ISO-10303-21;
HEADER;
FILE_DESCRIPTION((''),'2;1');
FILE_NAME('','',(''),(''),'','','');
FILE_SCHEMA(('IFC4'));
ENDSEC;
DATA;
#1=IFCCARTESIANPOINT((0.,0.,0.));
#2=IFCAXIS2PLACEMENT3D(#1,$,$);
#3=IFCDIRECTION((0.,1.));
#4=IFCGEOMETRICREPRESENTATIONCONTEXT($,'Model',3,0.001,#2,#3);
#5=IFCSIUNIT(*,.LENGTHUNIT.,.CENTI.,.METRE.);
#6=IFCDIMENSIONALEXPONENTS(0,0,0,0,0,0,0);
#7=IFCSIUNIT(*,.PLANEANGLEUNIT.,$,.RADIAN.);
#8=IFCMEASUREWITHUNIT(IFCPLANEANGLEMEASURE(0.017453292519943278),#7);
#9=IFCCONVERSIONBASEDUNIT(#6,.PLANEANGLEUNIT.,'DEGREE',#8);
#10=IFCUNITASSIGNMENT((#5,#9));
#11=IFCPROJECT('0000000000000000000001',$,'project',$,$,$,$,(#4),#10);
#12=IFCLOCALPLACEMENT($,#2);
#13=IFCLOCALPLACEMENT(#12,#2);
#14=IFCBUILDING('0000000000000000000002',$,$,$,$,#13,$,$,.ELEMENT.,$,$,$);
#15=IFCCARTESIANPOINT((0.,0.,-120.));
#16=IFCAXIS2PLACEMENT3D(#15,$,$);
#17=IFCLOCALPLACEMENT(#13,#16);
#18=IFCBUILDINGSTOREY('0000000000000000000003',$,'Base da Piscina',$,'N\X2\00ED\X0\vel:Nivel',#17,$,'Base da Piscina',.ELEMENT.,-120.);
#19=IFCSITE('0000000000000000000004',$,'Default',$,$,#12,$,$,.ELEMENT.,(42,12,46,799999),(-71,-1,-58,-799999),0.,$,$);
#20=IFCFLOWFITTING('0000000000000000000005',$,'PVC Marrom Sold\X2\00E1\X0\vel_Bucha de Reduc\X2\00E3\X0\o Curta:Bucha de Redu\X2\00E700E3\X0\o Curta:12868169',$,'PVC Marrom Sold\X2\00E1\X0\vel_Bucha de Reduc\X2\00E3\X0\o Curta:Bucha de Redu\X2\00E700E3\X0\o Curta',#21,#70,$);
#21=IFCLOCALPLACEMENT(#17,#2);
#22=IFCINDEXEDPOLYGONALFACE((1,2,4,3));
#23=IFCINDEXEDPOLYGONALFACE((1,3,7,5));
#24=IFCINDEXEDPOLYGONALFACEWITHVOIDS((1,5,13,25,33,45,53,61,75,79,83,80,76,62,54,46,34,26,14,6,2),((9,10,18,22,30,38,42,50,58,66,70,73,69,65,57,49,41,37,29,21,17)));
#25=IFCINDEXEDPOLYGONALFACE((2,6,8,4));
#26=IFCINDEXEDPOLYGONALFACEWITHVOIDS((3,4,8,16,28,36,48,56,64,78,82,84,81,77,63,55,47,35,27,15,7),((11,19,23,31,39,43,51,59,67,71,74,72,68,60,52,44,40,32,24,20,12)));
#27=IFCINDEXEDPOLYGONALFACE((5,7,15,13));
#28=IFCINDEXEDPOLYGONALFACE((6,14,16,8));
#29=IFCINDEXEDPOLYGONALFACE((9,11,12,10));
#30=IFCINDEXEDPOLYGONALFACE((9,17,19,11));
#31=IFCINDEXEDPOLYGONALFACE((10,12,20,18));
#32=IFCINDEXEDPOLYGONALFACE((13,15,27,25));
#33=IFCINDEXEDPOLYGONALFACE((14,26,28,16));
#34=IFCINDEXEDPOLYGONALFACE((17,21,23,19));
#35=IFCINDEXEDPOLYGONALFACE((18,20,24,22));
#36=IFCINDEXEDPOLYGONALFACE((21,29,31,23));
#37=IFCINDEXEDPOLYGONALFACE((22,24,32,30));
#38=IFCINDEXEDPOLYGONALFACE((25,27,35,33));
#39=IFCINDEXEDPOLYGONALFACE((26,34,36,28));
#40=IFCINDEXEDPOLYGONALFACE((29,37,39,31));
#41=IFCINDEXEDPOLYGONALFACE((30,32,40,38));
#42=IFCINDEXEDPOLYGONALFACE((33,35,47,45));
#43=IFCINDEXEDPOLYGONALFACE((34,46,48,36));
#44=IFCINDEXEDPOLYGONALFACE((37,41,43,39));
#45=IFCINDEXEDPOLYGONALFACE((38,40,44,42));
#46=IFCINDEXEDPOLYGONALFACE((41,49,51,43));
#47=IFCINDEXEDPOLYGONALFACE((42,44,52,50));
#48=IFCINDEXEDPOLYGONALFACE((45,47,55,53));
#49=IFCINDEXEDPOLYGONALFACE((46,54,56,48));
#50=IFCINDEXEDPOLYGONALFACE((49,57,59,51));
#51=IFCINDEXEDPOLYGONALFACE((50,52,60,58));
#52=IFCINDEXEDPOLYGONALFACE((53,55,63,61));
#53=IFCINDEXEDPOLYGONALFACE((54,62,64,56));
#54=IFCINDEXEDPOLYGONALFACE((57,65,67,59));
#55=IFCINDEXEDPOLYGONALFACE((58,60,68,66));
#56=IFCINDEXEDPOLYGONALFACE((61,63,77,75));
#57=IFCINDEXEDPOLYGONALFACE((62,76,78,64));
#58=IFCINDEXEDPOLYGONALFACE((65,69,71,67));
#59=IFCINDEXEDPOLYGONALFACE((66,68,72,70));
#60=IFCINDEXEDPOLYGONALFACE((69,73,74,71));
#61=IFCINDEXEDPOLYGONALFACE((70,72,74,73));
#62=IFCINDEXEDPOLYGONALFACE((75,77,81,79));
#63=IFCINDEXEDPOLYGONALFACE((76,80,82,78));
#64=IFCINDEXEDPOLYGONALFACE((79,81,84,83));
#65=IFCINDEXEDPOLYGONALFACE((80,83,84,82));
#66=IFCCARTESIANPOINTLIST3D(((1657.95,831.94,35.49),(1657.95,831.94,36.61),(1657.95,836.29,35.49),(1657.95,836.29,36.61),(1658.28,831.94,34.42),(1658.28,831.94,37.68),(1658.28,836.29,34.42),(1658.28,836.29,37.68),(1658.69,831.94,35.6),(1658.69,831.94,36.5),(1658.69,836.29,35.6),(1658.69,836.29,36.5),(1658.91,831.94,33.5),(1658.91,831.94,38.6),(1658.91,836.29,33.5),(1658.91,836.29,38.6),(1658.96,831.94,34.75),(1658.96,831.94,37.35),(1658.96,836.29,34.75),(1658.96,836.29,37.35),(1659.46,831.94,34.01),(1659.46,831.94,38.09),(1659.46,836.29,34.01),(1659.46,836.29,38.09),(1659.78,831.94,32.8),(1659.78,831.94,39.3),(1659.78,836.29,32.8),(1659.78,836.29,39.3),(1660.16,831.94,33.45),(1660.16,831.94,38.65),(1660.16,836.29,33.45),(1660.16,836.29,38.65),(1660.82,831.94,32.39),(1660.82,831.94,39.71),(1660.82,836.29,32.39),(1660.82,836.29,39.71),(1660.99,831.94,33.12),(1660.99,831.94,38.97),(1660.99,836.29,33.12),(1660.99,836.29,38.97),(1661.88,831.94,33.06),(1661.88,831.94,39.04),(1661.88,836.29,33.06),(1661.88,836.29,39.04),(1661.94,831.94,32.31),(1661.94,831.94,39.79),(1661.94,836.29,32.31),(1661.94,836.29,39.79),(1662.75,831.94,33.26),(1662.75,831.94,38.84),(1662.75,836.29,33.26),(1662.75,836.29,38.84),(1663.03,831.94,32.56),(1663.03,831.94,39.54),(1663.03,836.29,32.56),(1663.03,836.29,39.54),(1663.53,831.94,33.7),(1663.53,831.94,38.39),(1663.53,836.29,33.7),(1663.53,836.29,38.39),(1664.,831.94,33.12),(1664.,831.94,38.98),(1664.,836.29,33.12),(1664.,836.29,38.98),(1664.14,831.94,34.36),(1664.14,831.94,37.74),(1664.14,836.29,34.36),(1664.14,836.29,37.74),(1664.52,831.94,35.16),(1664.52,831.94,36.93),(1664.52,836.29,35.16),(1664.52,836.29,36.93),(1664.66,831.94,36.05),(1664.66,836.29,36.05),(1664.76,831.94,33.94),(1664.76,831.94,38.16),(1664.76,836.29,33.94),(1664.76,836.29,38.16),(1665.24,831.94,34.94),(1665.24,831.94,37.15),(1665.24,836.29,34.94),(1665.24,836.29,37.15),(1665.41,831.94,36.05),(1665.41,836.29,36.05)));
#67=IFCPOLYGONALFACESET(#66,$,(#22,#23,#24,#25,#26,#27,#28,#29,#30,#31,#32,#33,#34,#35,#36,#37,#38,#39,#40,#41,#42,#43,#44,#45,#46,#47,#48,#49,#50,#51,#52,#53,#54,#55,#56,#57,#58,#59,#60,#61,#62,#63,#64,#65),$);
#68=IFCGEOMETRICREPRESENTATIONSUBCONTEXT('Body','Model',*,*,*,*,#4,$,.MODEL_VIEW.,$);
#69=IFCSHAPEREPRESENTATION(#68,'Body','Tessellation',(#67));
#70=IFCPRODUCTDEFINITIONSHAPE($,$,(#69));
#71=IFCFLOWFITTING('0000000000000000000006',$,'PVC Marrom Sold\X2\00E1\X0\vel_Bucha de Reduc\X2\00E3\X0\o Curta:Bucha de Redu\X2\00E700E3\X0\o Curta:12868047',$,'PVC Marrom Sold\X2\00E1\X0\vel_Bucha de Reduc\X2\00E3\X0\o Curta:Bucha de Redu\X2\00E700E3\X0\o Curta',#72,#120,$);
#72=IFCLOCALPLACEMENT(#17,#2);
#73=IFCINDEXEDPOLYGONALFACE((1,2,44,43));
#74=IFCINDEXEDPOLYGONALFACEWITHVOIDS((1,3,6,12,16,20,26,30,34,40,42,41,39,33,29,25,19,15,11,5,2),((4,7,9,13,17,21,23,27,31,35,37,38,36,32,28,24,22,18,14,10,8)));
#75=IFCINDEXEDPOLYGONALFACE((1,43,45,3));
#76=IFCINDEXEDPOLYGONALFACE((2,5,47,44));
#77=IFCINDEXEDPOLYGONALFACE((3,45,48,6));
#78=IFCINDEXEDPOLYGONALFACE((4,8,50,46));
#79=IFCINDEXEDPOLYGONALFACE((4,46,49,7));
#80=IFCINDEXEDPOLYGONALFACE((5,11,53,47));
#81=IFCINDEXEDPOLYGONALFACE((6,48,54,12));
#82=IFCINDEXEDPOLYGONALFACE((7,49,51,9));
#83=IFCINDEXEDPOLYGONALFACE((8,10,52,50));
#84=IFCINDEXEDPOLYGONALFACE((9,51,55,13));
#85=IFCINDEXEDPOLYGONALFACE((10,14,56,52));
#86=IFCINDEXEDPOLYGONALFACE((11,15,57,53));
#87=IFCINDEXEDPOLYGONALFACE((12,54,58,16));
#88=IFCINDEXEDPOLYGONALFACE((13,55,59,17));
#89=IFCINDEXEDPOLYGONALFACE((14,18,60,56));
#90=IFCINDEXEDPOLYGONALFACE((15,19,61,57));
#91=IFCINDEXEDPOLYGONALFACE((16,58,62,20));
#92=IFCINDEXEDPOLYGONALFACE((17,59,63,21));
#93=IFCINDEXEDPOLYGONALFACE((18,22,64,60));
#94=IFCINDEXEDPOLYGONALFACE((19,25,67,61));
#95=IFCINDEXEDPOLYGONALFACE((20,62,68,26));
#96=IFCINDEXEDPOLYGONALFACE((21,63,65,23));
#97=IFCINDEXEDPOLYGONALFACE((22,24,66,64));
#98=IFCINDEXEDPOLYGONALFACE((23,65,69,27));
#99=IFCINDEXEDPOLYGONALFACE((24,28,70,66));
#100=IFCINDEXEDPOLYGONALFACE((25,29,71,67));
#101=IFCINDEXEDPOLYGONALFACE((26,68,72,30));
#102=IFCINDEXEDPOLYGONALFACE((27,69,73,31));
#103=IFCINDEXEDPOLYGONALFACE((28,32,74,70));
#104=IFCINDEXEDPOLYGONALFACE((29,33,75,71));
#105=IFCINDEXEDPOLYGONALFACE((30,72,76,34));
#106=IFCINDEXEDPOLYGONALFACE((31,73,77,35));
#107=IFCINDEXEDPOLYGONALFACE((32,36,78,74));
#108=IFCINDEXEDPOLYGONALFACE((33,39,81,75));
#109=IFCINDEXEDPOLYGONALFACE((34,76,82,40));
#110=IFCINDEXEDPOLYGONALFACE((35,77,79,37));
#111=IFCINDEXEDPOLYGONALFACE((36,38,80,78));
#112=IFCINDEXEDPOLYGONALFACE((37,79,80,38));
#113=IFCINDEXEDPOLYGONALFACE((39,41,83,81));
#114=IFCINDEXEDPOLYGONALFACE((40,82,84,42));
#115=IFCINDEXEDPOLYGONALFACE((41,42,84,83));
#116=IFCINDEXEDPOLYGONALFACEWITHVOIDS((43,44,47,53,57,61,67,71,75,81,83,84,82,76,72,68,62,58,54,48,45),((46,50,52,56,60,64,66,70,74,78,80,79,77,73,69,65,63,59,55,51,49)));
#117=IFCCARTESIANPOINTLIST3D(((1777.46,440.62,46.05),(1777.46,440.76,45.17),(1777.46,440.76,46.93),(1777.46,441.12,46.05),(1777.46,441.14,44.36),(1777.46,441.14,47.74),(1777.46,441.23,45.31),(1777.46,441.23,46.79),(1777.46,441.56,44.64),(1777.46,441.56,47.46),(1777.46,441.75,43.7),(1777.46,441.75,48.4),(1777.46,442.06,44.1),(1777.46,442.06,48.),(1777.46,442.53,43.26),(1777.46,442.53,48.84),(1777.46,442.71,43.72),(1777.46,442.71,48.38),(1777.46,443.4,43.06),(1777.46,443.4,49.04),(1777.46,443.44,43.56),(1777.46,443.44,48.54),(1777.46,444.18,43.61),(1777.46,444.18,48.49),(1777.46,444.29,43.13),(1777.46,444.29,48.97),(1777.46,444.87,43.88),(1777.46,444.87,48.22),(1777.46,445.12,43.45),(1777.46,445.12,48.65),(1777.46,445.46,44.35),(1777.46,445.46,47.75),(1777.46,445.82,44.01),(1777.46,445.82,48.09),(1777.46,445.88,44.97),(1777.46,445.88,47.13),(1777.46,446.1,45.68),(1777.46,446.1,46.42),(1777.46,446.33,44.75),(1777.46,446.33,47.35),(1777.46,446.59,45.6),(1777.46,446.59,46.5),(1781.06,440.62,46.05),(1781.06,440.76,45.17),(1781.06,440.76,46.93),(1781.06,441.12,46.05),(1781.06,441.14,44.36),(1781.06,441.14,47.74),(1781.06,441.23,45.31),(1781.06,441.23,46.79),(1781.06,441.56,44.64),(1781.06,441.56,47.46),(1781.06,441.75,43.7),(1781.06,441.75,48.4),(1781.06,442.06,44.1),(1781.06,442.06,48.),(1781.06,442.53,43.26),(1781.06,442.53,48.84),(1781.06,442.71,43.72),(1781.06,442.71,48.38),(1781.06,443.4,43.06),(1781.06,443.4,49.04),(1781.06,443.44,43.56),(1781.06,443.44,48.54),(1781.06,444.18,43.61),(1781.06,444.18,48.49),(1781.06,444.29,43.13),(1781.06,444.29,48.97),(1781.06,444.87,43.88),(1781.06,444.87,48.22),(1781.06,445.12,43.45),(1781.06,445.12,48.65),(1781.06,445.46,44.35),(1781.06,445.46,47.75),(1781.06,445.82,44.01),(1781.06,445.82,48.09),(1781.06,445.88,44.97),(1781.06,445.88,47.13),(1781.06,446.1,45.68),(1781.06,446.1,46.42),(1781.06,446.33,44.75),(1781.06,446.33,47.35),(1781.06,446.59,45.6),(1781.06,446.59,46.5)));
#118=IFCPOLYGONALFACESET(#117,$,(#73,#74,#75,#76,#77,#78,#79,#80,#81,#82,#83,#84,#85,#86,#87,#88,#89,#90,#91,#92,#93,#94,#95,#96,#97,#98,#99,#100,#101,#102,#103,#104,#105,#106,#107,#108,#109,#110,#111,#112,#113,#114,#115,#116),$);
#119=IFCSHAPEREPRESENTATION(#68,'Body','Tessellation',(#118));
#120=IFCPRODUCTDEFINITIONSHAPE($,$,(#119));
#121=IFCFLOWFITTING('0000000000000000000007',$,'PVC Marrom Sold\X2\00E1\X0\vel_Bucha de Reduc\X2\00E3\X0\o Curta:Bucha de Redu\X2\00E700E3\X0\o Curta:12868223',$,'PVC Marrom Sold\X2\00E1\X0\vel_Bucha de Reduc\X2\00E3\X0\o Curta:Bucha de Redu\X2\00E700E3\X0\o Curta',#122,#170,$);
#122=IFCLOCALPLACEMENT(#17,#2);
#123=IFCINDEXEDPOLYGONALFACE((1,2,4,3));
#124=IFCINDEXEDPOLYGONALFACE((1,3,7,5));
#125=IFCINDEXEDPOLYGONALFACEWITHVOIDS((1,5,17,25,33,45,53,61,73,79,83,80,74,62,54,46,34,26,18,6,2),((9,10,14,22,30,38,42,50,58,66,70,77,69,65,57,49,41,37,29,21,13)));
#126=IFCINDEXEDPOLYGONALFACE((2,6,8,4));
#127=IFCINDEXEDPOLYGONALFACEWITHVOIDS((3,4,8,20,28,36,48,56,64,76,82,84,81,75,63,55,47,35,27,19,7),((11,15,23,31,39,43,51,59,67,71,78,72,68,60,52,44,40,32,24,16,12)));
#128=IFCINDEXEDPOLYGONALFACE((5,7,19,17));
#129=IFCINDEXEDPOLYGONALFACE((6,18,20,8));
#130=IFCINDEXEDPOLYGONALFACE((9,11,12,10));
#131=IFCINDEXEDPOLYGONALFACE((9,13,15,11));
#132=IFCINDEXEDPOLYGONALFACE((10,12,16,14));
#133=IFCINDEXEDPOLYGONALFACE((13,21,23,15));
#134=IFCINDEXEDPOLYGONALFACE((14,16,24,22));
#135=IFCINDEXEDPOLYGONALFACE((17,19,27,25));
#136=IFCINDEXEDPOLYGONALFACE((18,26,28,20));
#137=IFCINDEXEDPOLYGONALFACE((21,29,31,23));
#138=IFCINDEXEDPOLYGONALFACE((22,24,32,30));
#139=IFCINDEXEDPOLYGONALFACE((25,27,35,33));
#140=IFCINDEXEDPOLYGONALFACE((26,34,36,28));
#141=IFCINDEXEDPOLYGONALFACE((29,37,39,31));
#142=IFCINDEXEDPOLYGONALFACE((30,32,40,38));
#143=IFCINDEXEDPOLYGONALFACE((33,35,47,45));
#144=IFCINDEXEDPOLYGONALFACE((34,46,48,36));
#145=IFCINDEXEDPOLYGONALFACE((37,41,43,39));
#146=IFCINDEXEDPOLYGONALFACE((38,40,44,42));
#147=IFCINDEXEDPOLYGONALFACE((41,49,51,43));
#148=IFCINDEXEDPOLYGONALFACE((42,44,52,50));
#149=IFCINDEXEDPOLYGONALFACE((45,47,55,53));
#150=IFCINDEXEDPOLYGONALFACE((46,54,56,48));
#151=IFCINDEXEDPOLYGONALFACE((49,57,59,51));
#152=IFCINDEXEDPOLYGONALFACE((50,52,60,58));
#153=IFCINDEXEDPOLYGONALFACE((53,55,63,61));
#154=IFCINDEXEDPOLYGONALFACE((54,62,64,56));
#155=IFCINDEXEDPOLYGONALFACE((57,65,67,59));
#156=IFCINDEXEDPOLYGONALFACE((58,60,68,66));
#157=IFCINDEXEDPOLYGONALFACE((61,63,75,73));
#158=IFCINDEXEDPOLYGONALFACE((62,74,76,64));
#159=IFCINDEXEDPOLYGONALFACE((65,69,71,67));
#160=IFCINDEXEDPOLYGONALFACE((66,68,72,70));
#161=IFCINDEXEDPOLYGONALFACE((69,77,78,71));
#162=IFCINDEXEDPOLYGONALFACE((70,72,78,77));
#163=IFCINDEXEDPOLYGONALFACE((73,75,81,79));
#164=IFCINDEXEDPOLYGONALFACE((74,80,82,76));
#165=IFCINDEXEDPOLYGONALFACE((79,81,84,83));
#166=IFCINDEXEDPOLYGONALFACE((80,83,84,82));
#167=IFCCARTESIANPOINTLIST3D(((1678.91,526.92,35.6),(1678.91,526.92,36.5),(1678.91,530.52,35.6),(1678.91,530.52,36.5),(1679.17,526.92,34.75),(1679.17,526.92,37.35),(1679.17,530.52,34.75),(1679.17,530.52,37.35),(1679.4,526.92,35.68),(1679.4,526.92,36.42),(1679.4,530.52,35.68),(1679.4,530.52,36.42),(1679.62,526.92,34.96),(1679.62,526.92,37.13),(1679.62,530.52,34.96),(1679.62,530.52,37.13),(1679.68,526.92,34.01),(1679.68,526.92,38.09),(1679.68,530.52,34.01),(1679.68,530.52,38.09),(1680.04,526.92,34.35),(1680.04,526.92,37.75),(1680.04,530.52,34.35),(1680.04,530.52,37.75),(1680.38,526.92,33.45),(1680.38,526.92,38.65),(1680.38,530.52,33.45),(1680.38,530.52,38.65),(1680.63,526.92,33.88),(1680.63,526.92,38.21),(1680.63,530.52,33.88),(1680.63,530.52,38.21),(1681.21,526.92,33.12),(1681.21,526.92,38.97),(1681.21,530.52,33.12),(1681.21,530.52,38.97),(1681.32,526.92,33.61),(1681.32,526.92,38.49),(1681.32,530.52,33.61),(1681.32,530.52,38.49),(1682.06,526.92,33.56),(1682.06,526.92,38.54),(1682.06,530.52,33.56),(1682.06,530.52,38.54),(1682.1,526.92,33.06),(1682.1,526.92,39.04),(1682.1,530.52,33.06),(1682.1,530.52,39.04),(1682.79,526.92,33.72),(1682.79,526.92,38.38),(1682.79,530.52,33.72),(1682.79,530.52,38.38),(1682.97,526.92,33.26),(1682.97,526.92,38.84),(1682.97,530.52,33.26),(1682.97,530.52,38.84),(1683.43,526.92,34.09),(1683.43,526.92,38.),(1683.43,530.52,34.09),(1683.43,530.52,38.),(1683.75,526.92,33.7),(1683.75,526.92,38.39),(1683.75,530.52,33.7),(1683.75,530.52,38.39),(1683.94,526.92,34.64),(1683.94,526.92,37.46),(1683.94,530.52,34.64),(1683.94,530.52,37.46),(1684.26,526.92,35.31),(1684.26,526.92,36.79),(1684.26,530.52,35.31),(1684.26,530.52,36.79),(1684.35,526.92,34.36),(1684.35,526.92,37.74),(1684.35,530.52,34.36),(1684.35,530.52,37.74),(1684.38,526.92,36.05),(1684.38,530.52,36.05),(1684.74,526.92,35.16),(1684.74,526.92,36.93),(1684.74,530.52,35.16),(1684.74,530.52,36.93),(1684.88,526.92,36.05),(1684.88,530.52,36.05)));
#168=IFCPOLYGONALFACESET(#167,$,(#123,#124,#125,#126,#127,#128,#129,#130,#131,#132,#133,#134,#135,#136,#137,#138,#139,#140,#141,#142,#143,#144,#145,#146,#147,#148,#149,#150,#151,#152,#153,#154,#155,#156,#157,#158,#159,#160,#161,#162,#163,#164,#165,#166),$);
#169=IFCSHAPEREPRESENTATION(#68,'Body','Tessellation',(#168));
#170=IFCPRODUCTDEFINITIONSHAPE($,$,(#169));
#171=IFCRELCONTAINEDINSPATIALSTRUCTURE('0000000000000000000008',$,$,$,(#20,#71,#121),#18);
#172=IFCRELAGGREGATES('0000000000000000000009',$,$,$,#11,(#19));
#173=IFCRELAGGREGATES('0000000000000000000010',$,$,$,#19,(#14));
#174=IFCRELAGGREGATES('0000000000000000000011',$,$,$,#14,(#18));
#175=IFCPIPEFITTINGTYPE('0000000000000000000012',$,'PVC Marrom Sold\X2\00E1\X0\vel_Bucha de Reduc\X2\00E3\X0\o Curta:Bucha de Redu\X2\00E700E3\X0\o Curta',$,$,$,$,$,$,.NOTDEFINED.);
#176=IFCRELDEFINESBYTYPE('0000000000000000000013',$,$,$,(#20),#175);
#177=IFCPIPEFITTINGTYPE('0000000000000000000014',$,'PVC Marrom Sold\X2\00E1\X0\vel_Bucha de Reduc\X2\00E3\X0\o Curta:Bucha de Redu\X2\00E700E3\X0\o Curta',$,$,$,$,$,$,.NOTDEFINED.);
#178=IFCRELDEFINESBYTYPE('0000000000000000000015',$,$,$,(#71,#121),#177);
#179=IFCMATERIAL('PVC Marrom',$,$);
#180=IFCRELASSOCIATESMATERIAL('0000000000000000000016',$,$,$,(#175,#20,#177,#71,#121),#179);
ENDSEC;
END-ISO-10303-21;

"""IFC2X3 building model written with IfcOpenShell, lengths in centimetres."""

from ifc_helpers import new_model, entity, si_unit, converted_unit, direction, frame, frame_2d, origin, place, context, subcontext, project, spatial, hollow_circle, extrude, source, transform, mapped, material, type_object, type_shapes, element, save


model = new_model("IFC2X3")

# Units and contexts
model_context = context("Model", 3, precision=0.001, world=origin(), true_north=direction((0.0, 1.0)))
body_context = subcontext(model_context, "Body", "Model", "MODEL_VIEW")
ifc_project = project(units=[si_unit("LENGTHUNIT", "METRE", prefix="CENTI"), converted_unit("PLANEANGLEUNIT", "DEGREE", entity("IfcPlaneAngleMeasure", 0.017453292519943278), si_unit("PLANEANGLEUNIT", "RADIAN"), dimensions=[0, 0, 0, 0, 0, 0, 0])], contexts=[model_context])

# Site, building, storey
site_placement = place(None, origin())
site = spatial("IfcSite", under=ifc_project, at=site_placement, Name="Default", CompositionType="ELEMENT", RefLatitude=(42, 12, 46, 799999), RefLongitude=(-71, -1, -58, -799999), RefElevation=0.0)
building_placement = place(site_placement, origin())
building = spatial("IfcBuilding", under=site, at=building_placement, CompositionType="ELEMENT")
storey_placement = place(building_placement, frame((0.0, 0.0, -120.0)))
storey = spatial("IfcBuildingStorey", under=building, at=storey_placement, Name="Base da Piscina", ObjectType="Nível:Nivel", LongName="Base da Piscina", CompositionType="ELEMENT", Elevation=-120.0)

# Flow fittings
ifc_material_1 = material(Name="PVC Marrom")
pipe_fitting_type_1 = type_object("IfcPipeFittingType", Name="PVC Marrom Soldável_Bucha de Reducão Curta:Bucha de Redução Curta", PredefinedType="NOTDEFINED", material=ifc_material_1)
shared_shape_1 = source(origin(), body_context, "Body", "SweptSolid", [
    extrude(hollow_circle(Radius=3.75, WallThickness=0.75, at=frame_2d((0.0, 0.0), x_axis=(1.0, 0.0))), frame((0.0, 0.0, 0.0), z_axis=(1.0, 0.0, 0.0), x_axis=(0.0, 1.0, 0.0)), (0.0, 0.0, 1.0), 4.35),
])
type_shapes(pipe_fitting_type_1, [shared_shape_1])
for number, where, z_axis, x_axis, name in (
    (1, (1661.66, 836.29, 36.05), (0.0, 0.0, 1.0), (0.0, -1.0, 0.0), "PVC Marrom Soldável_Bucha de Reducão Curta:Bucha de Redução Curta:12868169"),
):
    element("IfcFlowFitting", number, at=place(storey_placement, frame(where, z_axis=z_axis, x_axis=x_axis)), inside=storey, type_object=pipe_fitting_type_1, material=ifc_material_1, Name=name, ObjectType="PVC Marrom Soldável_Bucha de Reducão Curta:Bucha de Redução Curta", context=body_context, shape_type="MappedRepresentation", body=[
        mapped(shared_shape_1, transform((0.0, 0.0, 0.0), scale=1.0)),
    ])
pipe_fitting_type_2 = type_object("IfcPipeFittingType", Name="PVC Marrom Soldável_Bucha de Reducão Curta:Bucha de Redução Curta", PredefinedType="NOTDEFINED", material=ifc_material_1)
shared_shape_2 = source(origin(), body_context, "Body", "SweptSolid", [
    extrude(hollow_circle(Radius=3.0, WallThickness=0.5, at=frame_2d((0.0, 0.0), x_axis=(1.0, 0.0))), frame((0.0, 0.0, 0.0), z_axis=(1.0, 0.0, 0.0), x_axis=(0.0, 1.0, 0.0)), (0.0, 0.0, 1.0), 3.6),
])
type_shapes(pipe_fitting_type_2, [shared_shape_2])
for number, where, z_axis, x_axis, name in (
    (2, (1781.06, 443.62, 46.05), (0.0, 0.0, 1.0), (-1.0, 0.0, 0.0), "PVC Marrom Soldável_Bucha de Reducão Curta:Bucha de Redução Curta:12868047"),
    (3, (1681.88, 530.52, 36.05), (0.0, 0.0, 1.0), (0.0, -1.0, 0.0), "PVC Marrom Soldável_Bucha de Reducão Curta:Bucha de Redução Curta:12868223"),
):
    element("IfcFlowFitting", number, at=place(storey_placement, frame(where, z_axis=z_axis, x_axis=x_axis)), inside=storey, type_object=pipe_fitting_type_2, material=ifc_material_1, Name=name, ObjectType="PVC Marrom Soldável_Bucha de Reducão Curta:Bucha de Redução Curta", context=body_context, shape_type="MappedRepresentation", body=[
        mapped(shared_shape_2, transform((0.0, 0.0, 0.0), scale=1.0)),
    ])

save(model, "model.ifc")
